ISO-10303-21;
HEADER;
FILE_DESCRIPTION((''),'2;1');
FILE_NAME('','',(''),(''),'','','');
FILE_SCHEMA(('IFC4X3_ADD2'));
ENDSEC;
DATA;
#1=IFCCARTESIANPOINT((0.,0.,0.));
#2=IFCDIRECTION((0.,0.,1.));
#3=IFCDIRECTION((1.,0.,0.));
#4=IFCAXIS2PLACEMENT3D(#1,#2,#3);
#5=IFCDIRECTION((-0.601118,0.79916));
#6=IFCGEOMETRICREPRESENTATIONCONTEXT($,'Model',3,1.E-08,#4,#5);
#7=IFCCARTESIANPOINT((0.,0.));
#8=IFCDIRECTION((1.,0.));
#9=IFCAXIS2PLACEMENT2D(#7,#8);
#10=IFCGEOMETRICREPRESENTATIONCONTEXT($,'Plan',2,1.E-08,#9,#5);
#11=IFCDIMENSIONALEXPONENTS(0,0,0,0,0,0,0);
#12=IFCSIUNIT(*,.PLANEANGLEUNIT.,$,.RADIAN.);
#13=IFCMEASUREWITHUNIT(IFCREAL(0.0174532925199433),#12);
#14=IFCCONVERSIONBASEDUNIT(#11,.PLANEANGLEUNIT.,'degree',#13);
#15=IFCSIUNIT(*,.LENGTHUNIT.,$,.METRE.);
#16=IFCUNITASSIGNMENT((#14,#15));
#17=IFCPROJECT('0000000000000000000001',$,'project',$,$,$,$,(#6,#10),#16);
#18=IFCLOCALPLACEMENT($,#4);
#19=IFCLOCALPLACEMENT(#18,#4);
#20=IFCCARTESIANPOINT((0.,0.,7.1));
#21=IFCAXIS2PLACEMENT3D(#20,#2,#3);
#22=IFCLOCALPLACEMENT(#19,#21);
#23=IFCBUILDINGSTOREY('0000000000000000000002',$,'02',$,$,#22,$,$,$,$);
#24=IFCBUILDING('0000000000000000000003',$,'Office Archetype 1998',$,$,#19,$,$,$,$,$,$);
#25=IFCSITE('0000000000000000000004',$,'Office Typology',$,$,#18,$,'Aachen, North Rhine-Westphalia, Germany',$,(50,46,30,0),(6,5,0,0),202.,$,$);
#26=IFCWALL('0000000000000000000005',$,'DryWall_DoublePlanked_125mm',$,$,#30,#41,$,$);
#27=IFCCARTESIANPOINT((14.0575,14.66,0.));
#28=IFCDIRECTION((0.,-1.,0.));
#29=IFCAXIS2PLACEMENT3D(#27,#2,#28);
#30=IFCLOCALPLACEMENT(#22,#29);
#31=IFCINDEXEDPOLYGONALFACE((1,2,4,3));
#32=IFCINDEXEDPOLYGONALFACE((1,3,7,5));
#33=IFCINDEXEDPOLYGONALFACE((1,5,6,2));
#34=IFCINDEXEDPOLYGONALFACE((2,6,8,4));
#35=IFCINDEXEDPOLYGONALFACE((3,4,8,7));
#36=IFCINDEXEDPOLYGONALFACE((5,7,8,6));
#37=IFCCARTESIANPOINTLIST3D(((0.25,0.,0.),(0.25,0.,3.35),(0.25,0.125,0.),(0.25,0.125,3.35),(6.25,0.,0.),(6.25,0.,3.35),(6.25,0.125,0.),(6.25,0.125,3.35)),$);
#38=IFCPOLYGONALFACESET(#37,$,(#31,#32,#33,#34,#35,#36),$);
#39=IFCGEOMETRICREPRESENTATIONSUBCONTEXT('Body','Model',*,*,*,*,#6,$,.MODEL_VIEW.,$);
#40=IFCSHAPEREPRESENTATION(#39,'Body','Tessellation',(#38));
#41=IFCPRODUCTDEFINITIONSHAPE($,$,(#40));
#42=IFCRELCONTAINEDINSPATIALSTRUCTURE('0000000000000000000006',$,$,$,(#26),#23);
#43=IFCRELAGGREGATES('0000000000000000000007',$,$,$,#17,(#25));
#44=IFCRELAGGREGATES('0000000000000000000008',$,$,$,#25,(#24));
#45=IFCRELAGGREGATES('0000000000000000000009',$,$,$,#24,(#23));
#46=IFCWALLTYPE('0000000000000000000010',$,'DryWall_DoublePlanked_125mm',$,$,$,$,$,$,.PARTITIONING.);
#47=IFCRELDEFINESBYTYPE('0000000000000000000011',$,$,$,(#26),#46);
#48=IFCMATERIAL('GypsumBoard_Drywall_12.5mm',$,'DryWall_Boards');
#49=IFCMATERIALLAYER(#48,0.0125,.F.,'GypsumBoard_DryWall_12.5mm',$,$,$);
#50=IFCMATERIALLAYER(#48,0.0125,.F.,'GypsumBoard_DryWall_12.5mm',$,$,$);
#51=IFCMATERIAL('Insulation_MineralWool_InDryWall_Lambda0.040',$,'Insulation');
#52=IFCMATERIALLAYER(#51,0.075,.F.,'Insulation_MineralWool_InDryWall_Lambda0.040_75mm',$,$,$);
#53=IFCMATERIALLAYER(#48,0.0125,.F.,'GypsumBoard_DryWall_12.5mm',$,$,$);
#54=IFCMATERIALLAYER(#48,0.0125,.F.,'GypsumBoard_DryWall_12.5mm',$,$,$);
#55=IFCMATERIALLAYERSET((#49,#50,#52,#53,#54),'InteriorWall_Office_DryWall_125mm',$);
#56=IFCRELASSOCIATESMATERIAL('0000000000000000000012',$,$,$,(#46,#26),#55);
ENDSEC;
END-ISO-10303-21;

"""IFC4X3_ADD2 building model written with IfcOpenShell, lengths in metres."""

from ifc_helpers import new_model, entity, si_unit, converted_unit, direction, frame, origin_with_axes, origin_2d_with_axis, place, context, subcontext, project, spatial, line, indexed_curve, outline, extrude, material, layer, layer_set, layer_usage, type_object, element, save


model = new_model("IFC4X3_ADD2")

# Units and contexts
model_context = context("Model", 3, precision=1e-08, world=origin_with_axes(), true_north=direction((-0.601118, 0.79916)))
plan_context = context("Plan", 2, precision=1e-08, world=origin_2d_with_axis(), true_north=direction((-0.601118, 0.79916)))
body_context = subcontext(model_context, "Body", "Model", "MODEL_VIEW")
ifc_project = project(units=[converted_unit("PLANEANGLEUNIT", "degree", entity("IfcReal", 0.0174532925199433), si_unit("PLANEANGLEUNIT", "RADIAN"), dimensions=[0, 0, 0, 0, 0, 0, 0]), si_unit("LENGTHUNIT", "METRE")], contexts=[model_context, plan_context])

# Site, building, storey
site_placement = place(None, origin_with_axes())
site = spatial("IfcSite", under=ifc_project, at=site_placement, Name="Office Typology", LongName="Aachen, North Rhine-Westphalia, Germany", RefLatitude=(50, 46, 30, 0), RefLongitude=(6, 5, 0, 0), RefElevation=202.0)
building_placement = place(site_placement, origin_with_axes())
building = spatial("IfcBuilding", under=site, at=building_placement, Name="Office Archetype 1998")
storey_placement = place(building_placement, frame((0.0, 0.0, 7.1), z_axis=(0.0, 0.0, 1.0), x_axis=(1.0, 0.0, 0.0)))
storey = spatial("IfcBuildingStorey", under=building, at=storey_placement, Name="02")

# Wall
ifc_material_1 = material(Name="GypsumBoard_Drywall_12.5mm", Category="DryWall_Boards")
ifc_layer_1 = layer(ifc_material_1, 0.0125, ventilated=False, Name="GypsumBoard_DryWall_12.5mm")
ifc_layer_2 = layer(ifc_material_1, 0.0125, ventilated=False, Name="GypsumBoard_DryWall_12.5mm")
ifc_material_2 = material(Name="Insulation_MineralWool_InDryWall_Lambda0.040", Category="Insulation")
ifc_layer_3 = layer(ifc_material_2, 0.075, ventilated=False, Name="Insulation_MineralWool_InDryWall_Lambda0.040_75mm")
ifc_layer_4 = layer(ifc_material_1, 0.0125, ventilated=False, Name="GypsumBoard_DryWall_12.5mm")
ifc_layer_5 = layer(ifc_material_1, 0.0125, ventilated=False, Name="GypsumBoard_DryWall_12.5mm")
ifc_layer_set_1 = layer_set([ifc_layer_1, ifc_layer_2, ifc_layer_3, ifc_layer_4, ifc_layer_5], Name="InteriorWall_Office_DryWall_125mm")
ifc_layer_usage = layer_usage(ifc_layer_set_1, "AXIS2", "POSITIVE", 0.0)
wall_type_1 = type_object("IfcWallType", Name="DryWall_DoublePlanked_125mm", PredefinedType="PARTITIONING", material=ifc_layer_set_1)
wall_1_placement = place(storey_placement, frame((14.0575, 14.66, 0.0), z_axis=(0.0, 0.0, 1.0), x_axis=(0.0, -1.0, 0.0)))
element("IfcWall", 1, at=wall_1_placement, inside=storey, type_object=wall_type_1, material=ifc_layer_usage, Name="DryWall_DoublePlanked_125mm", context=body_context, shape_type="SweptSolid", body=[
    extrude(outline(indexed_curve([(0.25, 0.0), (0.25, 0.125), (6.25, 0.125), (6.25, 0.0)], segments=[line(1, 2, 3, 4, 1)])), origin_with_axes(), (0.0, 0.0, 1.0), 3.35),
])

save(model, "model.ifc")
